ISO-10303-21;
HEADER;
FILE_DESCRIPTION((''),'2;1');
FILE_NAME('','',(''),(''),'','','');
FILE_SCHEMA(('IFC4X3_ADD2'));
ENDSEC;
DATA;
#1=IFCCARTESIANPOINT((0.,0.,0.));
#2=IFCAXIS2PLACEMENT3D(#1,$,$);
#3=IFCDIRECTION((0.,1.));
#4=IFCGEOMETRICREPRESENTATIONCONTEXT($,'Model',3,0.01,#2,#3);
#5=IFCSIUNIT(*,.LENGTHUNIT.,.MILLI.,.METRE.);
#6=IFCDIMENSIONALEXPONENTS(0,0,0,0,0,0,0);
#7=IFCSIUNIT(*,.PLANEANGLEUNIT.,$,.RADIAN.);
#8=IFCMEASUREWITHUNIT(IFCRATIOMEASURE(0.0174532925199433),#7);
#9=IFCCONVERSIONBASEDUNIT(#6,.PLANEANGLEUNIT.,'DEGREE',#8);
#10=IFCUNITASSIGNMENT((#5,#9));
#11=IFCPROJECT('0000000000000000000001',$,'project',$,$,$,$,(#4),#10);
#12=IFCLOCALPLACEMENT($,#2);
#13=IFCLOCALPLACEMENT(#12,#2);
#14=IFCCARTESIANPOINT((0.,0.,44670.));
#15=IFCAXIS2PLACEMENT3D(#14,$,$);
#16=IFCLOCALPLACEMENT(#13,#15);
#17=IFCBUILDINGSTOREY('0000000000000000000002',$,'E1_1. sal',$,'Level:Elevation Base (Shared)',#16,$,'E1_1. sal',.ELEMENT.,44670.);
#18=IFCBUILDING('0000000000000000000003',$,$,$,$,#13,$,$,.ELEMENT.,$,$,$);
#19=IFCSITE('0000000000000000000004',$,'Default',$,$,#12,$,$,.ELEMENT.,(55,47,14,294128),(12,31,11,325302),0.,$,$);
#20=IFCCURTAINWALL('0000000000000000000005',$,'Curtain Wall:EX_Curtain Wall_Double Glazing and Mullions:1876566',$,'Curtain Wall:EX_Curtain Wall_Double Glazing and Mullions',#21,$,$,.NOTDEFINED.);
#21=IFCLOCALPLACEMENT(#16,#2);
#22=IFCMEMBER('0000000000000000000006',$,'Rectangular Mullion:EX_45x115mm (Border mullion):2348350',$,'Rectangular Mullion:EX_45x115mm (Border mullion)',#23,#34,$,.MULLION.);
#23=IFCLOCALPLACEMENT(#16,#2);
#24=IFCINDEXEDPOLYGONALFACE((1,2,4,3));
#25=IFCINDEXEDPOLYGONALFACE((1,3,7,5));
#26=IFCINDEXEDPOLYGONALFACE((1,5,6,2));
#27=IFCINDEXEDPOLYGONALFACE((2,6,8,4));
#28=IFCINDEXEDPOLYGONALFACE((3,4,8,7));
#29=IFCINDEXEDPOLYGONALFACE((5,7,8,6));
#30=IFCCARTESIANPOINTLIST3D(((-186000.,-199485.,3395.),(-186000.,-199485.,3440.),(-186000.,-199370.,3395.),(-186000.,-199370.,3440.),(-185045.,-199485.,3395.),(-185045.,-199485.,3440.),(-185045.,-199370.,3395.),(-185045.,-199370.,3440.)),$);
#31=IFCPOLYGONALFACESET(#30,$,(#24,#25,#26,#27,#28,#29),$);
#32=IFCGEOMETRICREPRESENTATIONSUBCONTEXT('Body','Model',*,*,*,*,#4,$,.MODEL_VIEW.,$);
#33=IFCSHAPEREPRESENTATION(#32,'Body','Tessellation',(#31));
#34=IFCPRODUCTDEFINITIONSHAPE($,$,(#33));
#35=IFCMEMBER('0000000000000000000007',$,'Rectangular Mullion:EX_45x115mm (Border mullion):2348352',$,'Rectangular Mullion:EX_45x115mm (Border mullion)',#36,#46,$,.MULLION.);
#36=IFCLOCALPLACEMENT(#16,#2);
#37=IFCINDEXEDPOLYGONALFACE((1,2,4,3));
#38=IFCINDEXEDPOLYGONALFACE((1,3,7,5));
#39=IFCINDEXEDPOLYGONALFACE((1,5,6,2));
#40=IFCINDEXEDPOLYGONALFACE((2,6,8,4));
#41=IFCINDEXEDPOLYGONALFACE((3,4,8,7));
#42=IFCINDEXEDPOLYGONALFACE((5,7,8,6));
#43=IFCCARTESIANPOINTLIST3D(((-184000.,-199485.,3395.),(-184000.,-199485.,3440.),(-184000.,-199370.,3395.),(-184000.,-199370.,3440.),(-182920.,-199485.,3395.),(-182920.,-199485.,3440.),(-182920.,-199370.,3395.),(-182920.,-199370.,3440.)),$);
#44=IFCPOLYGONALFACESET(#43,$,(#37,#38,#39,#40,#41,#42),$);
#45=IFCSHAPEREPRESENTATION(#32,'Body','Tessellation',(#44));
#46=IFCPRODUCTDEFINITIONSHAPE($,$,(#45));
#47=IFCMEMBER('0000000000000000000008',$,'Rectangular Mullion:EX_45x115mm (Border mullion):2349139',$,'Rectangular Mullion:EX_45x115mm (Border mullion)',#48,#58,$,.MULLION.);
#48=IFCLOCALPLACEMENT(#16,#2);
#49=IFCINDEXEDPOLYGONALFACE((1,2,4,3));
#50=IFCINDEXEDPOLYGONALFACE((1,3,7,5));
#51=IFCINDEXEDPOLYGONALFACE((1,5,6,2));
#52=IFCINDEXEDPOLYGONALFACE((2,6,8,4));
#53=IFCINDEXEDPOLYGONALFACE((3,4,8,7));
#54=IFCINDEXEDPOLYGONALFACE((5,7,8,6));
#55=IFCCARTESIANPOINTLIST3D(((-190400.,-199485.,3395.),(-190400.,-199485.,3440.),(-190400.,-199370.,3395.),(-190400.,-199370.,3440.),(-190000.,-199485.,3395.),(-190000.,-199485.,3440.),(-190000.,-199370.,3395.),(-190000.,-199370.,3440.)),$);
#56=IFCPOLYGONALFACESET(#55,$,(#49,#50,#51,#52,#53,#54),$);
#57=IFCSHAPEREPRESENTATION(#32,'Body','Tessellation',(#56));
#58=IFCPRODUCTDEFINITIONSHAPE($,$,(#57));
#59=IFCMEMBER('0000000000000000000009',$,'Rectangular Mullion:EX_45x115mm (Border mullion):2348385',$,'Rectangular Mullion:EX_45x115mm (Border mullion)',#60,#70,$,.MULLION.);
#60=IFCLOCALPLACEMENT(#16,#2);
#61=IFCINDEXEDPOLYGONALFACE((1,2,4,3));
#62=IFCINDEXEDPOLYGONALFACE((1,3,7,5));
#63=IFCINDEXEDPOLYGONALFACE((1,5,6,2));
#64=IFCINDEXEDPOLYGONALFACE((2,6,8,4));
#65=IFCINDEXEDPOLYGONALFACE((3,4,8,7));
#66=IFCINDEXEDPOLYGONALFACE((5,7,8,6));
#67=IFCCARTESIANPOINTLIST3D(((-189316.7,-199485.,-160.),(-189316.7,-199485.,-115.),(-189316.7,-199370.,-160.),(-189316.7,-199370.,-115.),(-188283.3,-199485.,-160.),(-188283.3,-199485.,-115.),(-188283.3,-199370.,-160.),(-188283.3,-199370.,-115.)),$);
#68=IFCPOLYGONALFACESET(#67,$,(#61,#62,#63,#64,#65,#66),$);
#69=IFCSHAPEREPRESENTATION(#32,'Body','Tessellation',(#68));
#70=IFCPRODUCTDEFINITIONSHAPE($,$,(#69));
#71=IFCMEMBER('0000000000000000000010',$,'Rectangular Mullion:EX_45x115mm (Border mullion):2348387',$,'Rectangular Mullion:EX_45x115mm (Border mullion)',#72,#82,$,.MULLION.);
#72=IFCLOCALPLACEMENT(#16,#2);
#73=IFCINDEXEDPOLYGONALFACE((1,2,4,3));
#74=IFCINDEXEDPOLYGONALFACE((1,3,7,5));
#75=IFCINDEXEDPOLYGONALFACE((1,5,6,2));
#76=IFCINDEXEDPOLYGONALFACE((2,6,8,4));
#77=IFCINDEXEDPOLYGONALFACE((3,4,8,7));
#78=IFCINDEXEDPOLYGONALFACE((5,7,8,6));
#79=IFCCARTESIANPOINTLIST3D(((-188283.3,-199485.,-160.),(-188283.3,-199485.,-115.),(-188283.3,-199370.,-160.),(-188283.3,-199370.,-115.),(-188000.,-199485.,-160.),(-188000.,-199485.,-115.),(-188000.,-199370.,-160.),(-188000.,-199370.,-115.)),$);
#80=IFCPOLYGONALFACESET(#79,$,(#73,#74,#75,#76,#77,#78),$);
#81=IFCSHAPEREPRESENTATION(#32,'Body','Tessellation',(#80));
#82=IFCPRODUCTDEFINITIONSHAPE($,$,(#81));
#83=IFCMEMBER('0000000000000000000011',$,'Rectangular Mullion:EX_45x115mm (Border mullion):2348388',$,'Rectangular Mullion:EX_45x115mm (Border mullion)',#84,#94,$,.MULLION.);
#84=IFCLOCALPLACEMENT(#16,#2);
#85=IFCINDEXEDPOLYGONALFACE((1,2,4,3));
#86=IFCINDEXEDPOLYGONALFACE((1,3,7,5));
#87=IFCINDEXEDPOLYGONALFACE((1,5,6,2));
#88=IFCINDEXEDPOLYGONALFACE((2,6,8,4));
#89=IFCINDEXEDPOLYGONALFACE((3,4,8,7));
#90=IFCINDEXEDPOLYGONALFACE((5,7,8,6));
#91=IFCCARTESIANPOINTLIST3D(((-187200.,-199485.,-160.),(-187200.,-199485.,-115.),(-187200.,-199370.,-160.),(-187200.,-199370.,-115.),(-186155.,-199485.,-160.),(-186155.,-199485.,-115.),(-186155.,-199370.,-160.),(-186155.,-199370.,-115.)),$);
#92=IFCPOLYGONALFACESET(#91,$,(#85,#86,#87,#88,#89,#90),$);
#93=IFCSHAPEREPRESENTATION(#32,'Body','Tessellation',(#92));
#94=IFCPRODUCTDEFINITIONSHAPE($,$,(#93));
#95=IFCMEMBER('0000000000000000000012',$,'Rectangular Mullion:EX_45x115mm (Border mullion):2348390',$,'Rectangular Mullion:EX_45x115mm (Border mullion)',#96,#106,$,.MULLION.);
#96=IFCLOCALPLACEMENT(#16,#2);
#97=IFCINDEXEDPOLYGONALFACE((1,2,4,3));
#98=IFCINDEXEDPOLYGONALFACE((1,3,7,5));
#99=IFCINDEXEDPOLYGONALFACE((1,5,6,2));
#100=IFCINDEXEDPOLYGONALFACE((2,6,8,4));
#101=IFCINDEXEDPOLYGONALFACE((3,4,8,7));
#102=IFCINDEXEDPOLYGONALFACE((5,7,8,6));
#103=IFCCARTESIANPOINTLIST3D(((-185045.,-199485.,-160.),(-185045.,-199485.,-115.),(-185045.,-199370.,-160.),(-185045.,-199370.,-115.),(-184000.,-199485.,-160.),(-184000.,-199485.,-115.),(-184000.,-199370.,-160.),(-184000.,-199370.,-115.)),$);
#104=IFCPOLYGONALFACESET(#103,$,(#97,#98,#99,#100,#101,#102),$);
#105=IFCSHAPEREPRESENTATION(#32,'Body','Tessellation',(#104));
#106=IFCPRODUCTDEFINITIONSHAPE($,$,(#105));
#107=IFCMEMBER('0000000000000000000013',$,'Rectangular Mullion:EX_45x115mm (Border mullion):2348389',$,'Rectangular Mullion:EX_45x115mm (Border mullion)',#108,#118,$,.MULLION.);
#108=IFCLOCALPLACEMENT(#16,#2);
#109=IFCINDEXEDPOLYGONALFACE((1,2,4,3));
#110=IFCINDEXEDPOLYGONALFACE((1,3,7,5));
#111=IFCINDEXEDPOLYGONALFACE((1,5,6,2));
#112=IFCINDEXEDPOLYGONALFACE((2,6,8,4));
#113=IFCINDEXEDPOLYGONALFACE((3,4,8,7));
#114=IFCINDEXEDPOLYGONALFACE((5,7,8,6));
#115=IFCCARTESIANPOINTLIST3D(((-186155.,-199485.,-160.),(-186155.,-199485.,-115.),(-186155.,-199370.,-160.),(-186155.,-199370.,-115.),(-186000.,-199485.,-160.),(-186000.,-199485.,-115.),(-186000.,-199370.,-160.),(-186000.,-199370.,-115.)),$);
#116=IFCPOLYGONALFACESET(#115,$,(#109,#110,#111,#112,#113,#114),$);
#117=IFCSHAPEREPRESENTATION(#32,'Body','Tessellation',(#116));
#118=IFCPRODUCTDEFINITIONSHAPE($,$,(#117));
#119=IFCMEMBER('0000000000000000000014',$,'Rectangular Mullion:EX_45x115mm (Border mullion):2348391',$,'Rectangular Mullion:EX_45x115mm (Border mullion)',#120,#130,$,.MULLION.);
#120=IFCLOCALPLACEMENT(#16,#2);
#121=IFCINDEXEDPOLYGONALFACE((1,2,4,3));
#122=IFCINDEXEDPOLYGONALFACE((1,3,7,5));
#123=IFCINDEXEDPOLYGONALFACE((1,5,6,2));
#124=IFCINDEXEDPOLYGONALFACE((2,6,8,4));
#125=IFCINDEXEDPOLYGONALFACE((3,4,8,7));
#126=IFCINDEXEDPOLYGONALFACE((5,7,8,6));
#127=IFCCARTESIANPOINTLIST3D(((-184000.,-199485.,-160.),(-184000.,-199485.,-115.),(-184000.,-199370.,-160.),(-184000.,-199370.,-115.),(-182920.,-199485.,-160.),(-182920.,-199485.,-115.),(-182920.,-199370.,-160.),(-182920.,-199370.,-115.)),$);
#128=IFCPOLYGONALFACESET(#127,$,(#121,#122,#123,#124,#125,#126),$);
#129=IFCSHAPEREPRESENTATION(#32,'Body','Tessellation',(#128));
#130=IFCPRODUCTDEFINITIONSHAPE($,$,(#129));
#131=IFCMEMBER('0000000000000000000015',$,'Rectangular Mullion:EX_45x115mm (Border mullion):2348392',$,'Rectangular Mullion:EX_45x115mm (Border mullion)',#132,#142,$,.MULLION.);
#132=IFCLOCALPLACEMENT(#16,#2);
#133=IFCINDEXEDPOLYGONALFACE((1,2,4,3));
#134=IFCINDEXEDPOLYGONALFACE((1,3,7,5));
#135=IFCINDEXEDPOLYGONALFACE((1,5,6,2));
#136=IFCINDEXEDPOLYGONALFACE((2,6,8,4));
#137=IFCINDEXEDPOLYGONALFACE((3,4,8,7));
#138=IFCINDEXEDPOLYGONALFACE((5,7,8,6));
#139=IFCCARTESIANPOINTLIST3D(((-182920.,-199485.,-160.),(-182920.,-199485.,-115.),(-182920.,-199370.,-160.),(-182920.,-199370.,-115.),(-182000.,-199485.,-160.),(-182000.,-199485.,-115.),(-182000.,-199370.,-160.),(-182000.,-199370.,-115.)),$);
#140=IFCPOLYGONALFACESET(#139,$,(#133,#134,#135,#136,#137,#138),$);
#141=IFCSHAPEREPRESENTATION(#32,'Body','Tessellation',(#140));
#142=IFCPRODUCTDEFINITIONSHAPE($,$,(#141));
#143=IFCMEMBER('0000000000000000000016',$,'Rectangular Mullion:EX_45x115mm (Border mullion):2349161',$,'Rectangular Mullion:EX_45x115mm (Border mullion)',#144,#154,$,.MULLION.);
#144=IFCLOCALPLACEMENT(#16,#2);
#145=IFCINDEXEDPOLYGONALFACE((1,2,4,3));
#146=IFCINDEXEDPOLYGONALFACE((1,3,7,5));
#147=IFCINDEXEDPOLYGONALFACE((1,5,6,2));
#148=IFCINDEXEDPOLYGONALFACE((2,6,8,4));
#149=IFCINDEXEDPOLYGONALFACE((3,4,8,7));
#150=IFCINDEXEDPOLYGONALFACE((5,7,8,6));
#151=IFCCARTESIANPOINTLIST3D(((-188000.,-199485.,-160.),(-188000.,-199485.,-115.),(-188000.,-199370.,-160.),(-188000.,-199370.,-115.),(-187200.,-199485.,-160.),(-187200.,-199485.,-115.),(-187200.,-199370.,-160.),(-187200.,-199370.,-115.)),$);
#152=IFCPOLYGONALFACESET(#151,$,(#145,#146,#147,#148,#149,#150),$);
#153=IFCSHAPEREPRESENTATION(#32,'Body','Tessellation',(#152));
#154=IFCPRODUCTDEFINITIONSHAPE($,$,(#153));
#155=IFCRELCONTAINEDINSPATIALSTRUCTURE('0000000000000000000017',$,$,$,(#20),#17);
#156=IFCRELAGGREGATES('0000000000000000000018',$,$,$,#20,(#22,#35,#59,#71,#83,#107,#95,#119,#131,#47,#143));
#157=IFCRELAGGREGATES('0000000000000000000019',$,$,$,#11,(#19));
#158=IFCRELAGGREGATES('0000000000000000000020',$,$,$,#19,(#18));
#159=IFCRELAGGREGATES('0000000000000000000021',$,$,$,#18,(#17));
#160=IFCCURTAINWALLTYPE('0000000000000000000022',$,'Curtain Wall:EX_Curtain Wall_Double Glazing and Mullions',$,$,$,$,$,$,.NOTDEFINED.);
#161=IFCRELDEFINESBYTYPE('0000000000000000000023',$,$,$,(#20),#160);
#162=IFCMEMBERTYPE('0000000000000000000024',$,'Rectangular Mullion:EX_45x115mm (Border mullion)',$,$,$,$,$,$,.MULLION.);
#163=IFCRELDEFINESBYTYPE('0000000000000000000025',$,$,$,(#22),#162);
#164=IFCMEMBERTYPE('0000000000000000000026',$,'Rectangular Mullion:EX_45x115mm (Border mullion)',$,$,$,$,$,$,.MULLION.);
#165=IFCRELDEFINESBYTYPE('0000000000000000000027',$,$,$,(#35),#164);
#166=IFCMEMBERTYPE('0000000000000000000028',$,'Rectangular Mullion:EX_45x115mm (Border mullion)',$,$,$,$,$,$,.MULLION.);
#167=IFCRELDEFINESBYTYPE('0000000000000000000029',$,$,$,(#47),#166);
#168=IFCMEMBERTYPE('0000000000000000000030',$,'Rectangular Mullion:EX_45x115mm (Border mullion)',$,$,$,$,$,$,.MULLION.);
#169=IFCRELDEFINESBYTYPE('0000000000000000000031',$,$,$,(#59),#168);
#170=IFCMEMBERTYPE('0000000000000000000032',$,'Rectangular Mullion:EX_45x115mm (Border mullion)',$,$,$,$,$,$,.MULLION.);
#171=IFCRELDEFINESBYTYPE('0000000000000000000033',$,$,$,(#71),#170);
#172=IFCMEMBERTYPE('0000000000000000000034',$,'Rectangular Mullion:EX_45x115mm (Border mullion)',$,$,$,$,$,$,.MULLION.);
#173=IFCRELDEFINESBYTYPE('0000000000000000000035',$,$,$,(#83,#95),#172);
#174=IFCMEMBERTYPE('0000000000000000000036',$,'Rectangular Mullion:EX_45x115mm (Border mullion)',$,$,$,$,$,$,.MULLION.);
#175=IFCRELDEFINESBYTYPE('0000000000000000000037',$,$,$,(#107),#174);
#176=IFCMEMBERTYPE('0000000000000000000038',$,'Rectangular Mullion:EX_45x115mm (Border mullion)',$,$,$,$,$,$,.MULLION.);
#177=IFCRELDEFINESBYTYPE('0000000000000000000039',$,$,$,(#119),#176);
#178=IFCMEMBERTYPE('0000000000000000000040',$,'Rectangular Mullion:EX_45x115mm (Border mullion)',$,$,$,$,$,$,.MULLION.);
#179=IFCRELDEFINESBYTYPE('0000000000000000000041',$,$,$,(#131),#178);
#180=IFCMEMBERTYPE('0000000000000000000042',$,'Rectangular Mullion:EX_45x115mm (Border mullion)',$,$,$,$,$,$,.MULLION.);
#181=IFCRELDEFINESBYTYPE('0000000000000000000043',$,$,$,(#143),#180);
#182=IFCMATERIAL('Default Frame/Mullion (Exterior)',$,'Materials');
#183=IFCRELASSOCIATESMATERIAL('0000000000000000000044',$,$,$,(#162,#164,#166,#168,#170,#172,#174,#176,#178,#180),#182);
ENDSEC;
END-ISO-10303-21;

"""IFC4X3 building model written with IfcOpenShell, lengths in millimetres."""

from ifc_helpers import new_model, entity, si_unit, converted_unit, direction, frame, origin, origin_2d_with_axis, place, context, subcontext, project, spatial, rectangle, extrude, source, transform, mapped, material, material_profile, profile_set, type_object, type_shapes, element, aggregate, save


model = new_model("IFC4X3")

# Units and contexts
model_context = context("Model", 3, precision=0.01, world=origin(), true_north=direction((0.0, 1.0)))
body_context = subcontext(model_context, "Body", "Model", "MODEL_VIEW")
ifc_project = project(units=[si_unit("LENGTHUNIT", "METRE", prefix="MILLI"), converted_unit("PLANEANGLEUNIT", "DEGREE", entity("IfcRatioMeasure", 0.0174532925199433), si_unit("PLANEANGLEUNIT", "RADIAN"), dimensions=[0, 0, 0, 0, 0, 0, 0])], contexts=[model_context])

# Site, building, storey
site_placement = place(None, origin())
site = spatial("IfcSite", under=ifc_project, at=site_placement, Name="Default", CompositionType="ELEMENT", RefLatitude=(55, 47, 14, 294128), RefLongitude=(12, 31, 11, 325302), RefElevation=0.0)
building_placement = place(site_placement, origin())
building = spatial("IfcBuilding", under=site, at=building_placement, CompositionType="ELEMENT")
storey_placement = place(building_placement, frame((0.0, 0.0, 44670.0)))
storey = spatial("IfcBuildingStorey", under=building, at=storey_placement, Name="E1_1. sal", ObjectType="Level:Elevation Base (Shared)", LongName="E1_1. sal", CompositionType="ELEMENT", Elevation=44670.0)

# Curtain wall, members
curtain_wall_type = type_object("IfcCurtainWallType", Name="Curtain Wall:EX_Curtain Wall_Double Glazing and Mullions", PredefinedType="NOTDEFINED")
curtain_wall_placement = place(storey_placement, frame((0.0, 0.0, -44670.0)))
curtain_wall = element("IfcCurtainWall", 1, at=curtain_wall_placement, inside=storey, type_object=curtain_wall_type, Name="Curtain Wall:EX_Curtain Wall_Double Glazing and Mullions:1876566", ObjectType="Curtain Wall:EX_Curtain Wall_Double Glazing and Mullions", PredefinedType="NOTDEFINED")
ifc_material_1 = material(Name="Default Frame/Mullion (Exterior)", Category="Materials")
ifc_material_profile_1 = material_profile(ifc_material_1, rectangle(XDim=115.0, YDim=45.0, at=origin_2d_with_axis()), Name="EX_45x115mm (Border mullion)")
ifc_profile_set_1 = profile_set([ifc_material_profile_1], Name="EX_45x115mm (Border mullion)")
member_type_1 = type_object("IfcMemberType", Name="Rectangular Mullion:EX_45x115mm (Border mullion)", PredefinedType="MULLION", material=ifc_profile_set_1)
shared_shape_1 = source(origin(), body_context, "Body", "SweptSolid", [
    extrude(rectangle(XDim=115.0, YDim=45.0, at=origin_2d_with_axis()), frame((-22.5, -57.5, -955.0), z_axis=(0.0, 0.0, 1.0), x_axis=(0.0, -1.0, 0.0)), (0.0, 0.0, 1.0), 955.0),
])
type_shapes(member_type_1, [shared_shape_1])
member_1_placement = place(curtain_wall_placement, frame((-185045.0, -199485.0, 48110.0), z_axis=(1.0, 0.0, 0.0), x_axis=(0.0, 0.0, 1.0)))
member_1 = element("IfcMember", 2, at=member_1_placement, type_object=member_type_1, Name="Rectangular Mullion:EX_45x115mm (Border mullion):2348350", ObjectType="Rectangular Mullion:EX_45x115mm (Border mullion)", PredefinedType="MULLION", context=body_context, shape_type="MappedRepresentation", body=[
    mapped(shared_shape_1, transform((0.0, 0.0, 0.0), scale=1.0)),
])
member_type_2 = type_object("IfcMemberType", Name="Rectangular Mullion:EX_45x115mm (Border mullion)", PredefinedType="MULLION", material=ifc_profile_set_1)
shared_shape_2 = source(origin(), body_context, "Body", "SweptSolid", [
    extrude(rectangle(XDim=115.0, YDim=45.0, at=origin_2d_with_axis()), frame((-22.5, -57.5, -1080.0), z_axis=(0.0, 0.0, 1.0), x_axis=(0.0, -1.0, 0.0)), (0.0, 0.0, 1.0), 1080.0),
])
type_shapes(member_type_2, [shared_shape_2])
member_2_placement = place(curtain_wall_placement, frame((-182920.0, -199485.0, 48110.0), z_axis=(1.0, 0.0, 0.0), x_axis=(0.0, 0.0, 1.0)))
member_2 = element("IfcMember", 3, at=member_2_placement, type_object=member_type_2, Name="Rectangular Mullion:EX_45x115mm (Border mullion):2348352", ObjectType="Rectangular Mullion:EX_45x115mm (Border mullion)", PredefinedType="MULLION", context=body_context, shape_type="MappedRepresentation", body=[
    mapped(shared_shape_2, transform((0.0, 0.0, 0.0), scale=1.0)),
])
member_type_3 = type_object("IfcMemberType", Name="Rectangular Mullion:EX_45x115mm (Border mullion)", PredefinedType="MULLION", material=ifc_profile_set_1)
shared_shape_3 = source(origin(), body_context, "Body", "SweptSolid", [
    extrude(rectangle(XDim=115.0, YDim=45.0, at=origin_2d_with_axis()), frame((-22.5, -57.5, -400.0), z_axis=(0.0, 0.0, 1.0), x_axis=(0.0, -1.0, 0.0)), (0.0, 0.0, 1.0), 400.0),
])
type_shapes(member_type_3, [shared_shape_3])
member_3_placement = place(curtain_wall_placement, frame((-190000.0, -199485.0, 48110.0), z_axis=(1.0, 0.0, 0.0), x_axis=(0.0, 0.0, 1.0)))
member_3 = element("IfcMember", 4, at=member_3_placement, type_object=member_type_3, Name="Rectangular Mullion:EX_45x115mm (Border mullion):2349139", ObjectType="Rectangular Mullion:EX_45x115mm (Border mullion)", PredefinedType="MULLION", context=body_context, shape_type="MappedRepresentation", body=[
    mapped(shared_shape_3, transform((0.0, 0.0, 0.0), scale=1.0)),
])
member_type_4 = type_object("IfcMemberType", Name="Rectangular Mullion:EX_45x115mm (Border mullion)", PredefinedType="MULLION", material=ifc_profile_set_1)
shared_shape_4 = source(origin(), body_context, "Body", "SweptSolid", [
    extrude(rectangle(XDim=115.0, YDim=45.0, at=origin_2d_with_axis()), frame((-22.5, -57.5, -1033.3), z_axis=(0.0, 0.0, 1.0), x_axis=(0.0, -1.0, 0.0)), (0.0, 0.0, 1.0), 1033.3),
])
type_shapes(member_type_4, [shared_shape_4])
member_4_placement = place(curtain_wall_placement, frame((-189316.7, -199485.0, 44510.0), z_axis=(-1.0, 0.0, 0.0), x_axis=(0.0, 0.0, -1.0)))
member_4 = element("IfcMember", 5, at=member_4_placement, type_object=member_type_4, Name="Rectangular Mullion:EX_45x115mm (Border mullion):2348385", ObjectType="Rectangular Mullion:EX_45x115mm (Border mullion)", PredefinedType="MULLION", context=body_context, shape_type="MappedRepresentation", body=[
    mapped(shared_shape_4, transform((0.0, 0.0, 0.0), scale=1.0)),
])
member_type_5 = type_object("IfcMemberType", Name="Rectangular Mullion:EX_45x115mm (Border mullion)", PredefinedType="MULLION", material=ifc_profile_set_1)
shared_shape_5 = source(origin(), body_context, "Body", "SweptSolid", [
    extrude(rectangle(XDim=115.0, YDim=45.0, at=origin_2d_with_axis()), frame((-22.5, -57.5, -283.3), z_axis=(0.0, 0.0, 1.0), x_axis=(0.0, -1.0, 0.0)), (0.0, 0.0, 1.0), 283.3),
])
type_shapes(member_type_5, [shared_shape_5])
member_5_placement = place(curtain_wall_placement, frame((-188283.3, -199485.0, 44510.0), z_axis=(-1.0, 0.0, 0.0), x_axis=(0.0, 0.0, -1.0)))
member_5 = element("IfcMember", 6, at=member_5_placement, type_object=member_type_5, Name="Rectangular Mullion:EX_45x115mm (Border mullion):2348387", ObjectType="Rectangular Mullion:EX_45x115mm (Border mullion)", PredefinedType="MULLION", context=body_context, shape_type="MappedRepresentation", body=[
    mapped(shared_shape_5, transform((0.0, 0.0, 0.0), scale=1.0)),
])
member_type_6 = type_object("IfcMemberType", Name="Rectangular Mullion:EX_45x115mm (Border mullion)", PredefinedType="MULLION", material=ifc_profile_set_1)
shared_shape_6 = source(origin(), body_context, "Body", "SweptSolid", [
    extrude(rectangle(XDim=115.0, YDim=45.0, at=origin_2d_with_axis()), frame((-22.5, -57.5, -1045.0), z_axis=(0.0, 0.0, 1.0), x_axis=(0.0, -1.0, 0.0)), (0.0, 0.0, 1.0), 1045.0),
])
type_shapes(member_type_6, [shared_shape_6])
member_6_placement = place(curtain_wall_placement, frame((-187200.0, -199485.0, 44510.0), z_axis=(-1.0, 0.0, 0.0), x_axis=(0.0, 0.0, -1.0)))
member_6 = element("IfcMember", 7, at=member_6_placement, type_object=member_type_6, Name="Rectangular Mullion:EX_45x115mm (Border mullion):2348388", ObjectType="Rectangular Mullion:EX_45x115mm (Border mullion)", PredefinedType="MULLION", context=body_context, shape_type="MappedRepresentation", body=[
    mapped(shared_shape_6, transform((0.0, 0.0, 0.0), scale=1.0)),
])
member_7_placement = place(curtain_wall_placement, frame((-185045.0, -199485.0, 44510.0), z_axis=(-1.0, 0.0, 0.0), x_axis=(0.0, 0.0, -1.0)))
member_7 = element("IfcMember", 8, at=member_7_placement, type_object=member_type_6, Name="Rectangular Mullion:EX_45x115mm (Border mullion):2348390", ObjectType="Rectangular Mullion:EX_45x115mm (Border mullion)", PredefinedType="MULLION", context=body_context, shape_type="MappedRepresentation", body=[
    mapped(shared_shape_6, transform((0.0, 0.0, 0.0), scale=1.0)),
])
member_type_7 = type_object("IfcMemberType", Name="Rectangular Mullion:EX_45x115mm (Border mullion)", PredefinedType="MULLION", material=ifc_profile_set_1)
shared_shape_7 = source(origin(), body_context, "Body", "SweptSolid", [
    extrude(rectangle(XDim=115.0, YDim=45.0, at=origin_2d_with_axis()), frame((-22.5, -57.5, -155.0), z_axis=(0.0, 0.0, 1.0), x_axis=(0.0, -1.0, 0.0)), (0.0, 0.0, 1.0), 155.0),
])
type_shapes(member_type_7, [shared_shape_7])
member_8_placement = place(curtain_wall_placement, frame((-186155.0, -199485.0, 44510.0), z_axis=(-1.0, 0.0, 0.0), x_axis=(0.0, 0.0, -1.0)))
member_8 = element("IfcMember", 9, at=member_8_placement, type_object=member_type_7, Name="Rectangular Mullion:EX_45x115mm (Border mullion):2348389", ObjectType="Rectangular Mullion:EX_45x115mm (Border mullion)", PredefinedType="MULLION", context=body_context, shape_type="MappedRepresentation", body=[
    mapped(shared_shape_7, transform((0.0, 0.0, 0.0), scale=1.0)),
])
member_type_8 = type_object("IfcMemberType", Name="Rectangular Mullion:EX_45x115mm (Border mullion)", PredefinedType="MULLION", material=ifc_profile_set_1)
shared_shape_8 = source(origin(), body_context, "Body", "SweptSolid", [
    extrude(rectangle(XDim=115.0, YDim=45.0, at=origin_2d_with_axis()), frame((-22.5, -57.5, -1080.0), z_axis=(0.0, 0.0, 1.0), x_axis=(0.0, -1.0, 0.0)), (0.0, 0.0, 1.0), 1080.0),
])
type_shapes(member_type_8, [shared_shape_8])
member_9_placement = place(curtain_wall_placement, frame((-184000.0, -199485.0, 44510.0), z_axis=(-1.0, 0.0, 0.0), x_axis=(0.0, 0.0, -1.0)))
member_9 = element("IfcMember", 10, at=member_9_placement, type_object=member_type_8, Name="Rectangular Mullion:EX_45x115mm (Border mullion):2348391", ObjectType="Rectangular Mullion:EX_45x115mm (Border mullion)", PredefinedType="MULLION", context=body_context, shape_type="MappedRepresentation", body=[
    mapped(shared_shape_8, transform((0.0, 0.0, 0.0), scale=1.0)),
])
member_type_9 = type_object("IfcMemberType", Name="Rectangular Mullion:EX_45x115mm (Border mullion)", PredefinedType="MULLION", material=ifc_profile_set_1)
shared_shape_9 = source(origin(), body_context, "Body", "SweptSolid", [
    extrude(rectangle(XDim=115.0, YDim=45.0, at=origin_2d_with_axis()), frame((-22.5, -57.5, -920.0), z_axis=(0.0, 0.0, 1.0), x_axis=(0.0, -1.0, 0.0)), (0.0, 0.0, 1.0), 920.0),
])
type_shapes(member_type_9, [shared_shape_9])
member_10_placement = place(curtain_wall_placement, frame((-182920.0, -199485.0, 44510.0), z_axis=(-1.0, 0.0, 0.0), x_axis=(0.0, 0.0, -1.0)))
member_10 = element("IfcMember", 11, at=member_10_placement, type_object=member_type_9, Name="Rectangular Mullion:EX_45x115mm (Border mullion):2348392", ObjectType="Rectangular Mullion:EX_45x115mm (Border mullion)", PredefinedType="MULLION", context=body_context, shape_type="MappedRepresentation", body=[
    mapped(shared_shape_9, transform((0.0, 0.0, 0.0), scale=1.0)),
])
member_type_10 = type_object("IfcMemberType", Name="Rectangular Mullion:EX_45x115mm (Border mullion)", PredefinedType="MULLION", material=ifc_profile_set_1)
shared_shape_10 = source(origin(), body_context, "Body", "SweptSolid", [
    extrude(rectangle(XDim=115.0, YDim=45.0, at=origin_2d_with_axis()), frame((-22.5, -57.5, -800.0), z_axis=(0.0, 0.0, 1.0), x_axis=(0.0, -1.0, 0.0)), (0.0, 0.0, 1.0), 800.0),
])
type_shapes(member_type_10, [shared_shape_10])
member_11_placement = place(curtain_wall_placement, frame((-188000.0, -199485.0, 44510.0), z_axis=(-1.0, 0.0, 0.0), x_axis=(0.0, 0.0, -1.0)))
member_11 = element("IfcMember", 12, at=member_11_placement, type_object=member_type_10, Name="Rectangular Mullion:EX_45x115mm (Border mullion):2349161", ObjectType="Rectangular Mullion:EX_45x115mm (Border mullion)", PredefinedType="MULLION", context=body_context, shape_type="MappedRepresentation", body=[
    mapped(shared_shape_10, transform((0.0, 0.0, 0.0), scale=1.0)),
])
aggregate(curtain_wall, [member_1, member_2, member_4, member_5, member_6, member_8, member_7, member_9, member_10, member_3, member_11])

save(model, "model.ifc")
